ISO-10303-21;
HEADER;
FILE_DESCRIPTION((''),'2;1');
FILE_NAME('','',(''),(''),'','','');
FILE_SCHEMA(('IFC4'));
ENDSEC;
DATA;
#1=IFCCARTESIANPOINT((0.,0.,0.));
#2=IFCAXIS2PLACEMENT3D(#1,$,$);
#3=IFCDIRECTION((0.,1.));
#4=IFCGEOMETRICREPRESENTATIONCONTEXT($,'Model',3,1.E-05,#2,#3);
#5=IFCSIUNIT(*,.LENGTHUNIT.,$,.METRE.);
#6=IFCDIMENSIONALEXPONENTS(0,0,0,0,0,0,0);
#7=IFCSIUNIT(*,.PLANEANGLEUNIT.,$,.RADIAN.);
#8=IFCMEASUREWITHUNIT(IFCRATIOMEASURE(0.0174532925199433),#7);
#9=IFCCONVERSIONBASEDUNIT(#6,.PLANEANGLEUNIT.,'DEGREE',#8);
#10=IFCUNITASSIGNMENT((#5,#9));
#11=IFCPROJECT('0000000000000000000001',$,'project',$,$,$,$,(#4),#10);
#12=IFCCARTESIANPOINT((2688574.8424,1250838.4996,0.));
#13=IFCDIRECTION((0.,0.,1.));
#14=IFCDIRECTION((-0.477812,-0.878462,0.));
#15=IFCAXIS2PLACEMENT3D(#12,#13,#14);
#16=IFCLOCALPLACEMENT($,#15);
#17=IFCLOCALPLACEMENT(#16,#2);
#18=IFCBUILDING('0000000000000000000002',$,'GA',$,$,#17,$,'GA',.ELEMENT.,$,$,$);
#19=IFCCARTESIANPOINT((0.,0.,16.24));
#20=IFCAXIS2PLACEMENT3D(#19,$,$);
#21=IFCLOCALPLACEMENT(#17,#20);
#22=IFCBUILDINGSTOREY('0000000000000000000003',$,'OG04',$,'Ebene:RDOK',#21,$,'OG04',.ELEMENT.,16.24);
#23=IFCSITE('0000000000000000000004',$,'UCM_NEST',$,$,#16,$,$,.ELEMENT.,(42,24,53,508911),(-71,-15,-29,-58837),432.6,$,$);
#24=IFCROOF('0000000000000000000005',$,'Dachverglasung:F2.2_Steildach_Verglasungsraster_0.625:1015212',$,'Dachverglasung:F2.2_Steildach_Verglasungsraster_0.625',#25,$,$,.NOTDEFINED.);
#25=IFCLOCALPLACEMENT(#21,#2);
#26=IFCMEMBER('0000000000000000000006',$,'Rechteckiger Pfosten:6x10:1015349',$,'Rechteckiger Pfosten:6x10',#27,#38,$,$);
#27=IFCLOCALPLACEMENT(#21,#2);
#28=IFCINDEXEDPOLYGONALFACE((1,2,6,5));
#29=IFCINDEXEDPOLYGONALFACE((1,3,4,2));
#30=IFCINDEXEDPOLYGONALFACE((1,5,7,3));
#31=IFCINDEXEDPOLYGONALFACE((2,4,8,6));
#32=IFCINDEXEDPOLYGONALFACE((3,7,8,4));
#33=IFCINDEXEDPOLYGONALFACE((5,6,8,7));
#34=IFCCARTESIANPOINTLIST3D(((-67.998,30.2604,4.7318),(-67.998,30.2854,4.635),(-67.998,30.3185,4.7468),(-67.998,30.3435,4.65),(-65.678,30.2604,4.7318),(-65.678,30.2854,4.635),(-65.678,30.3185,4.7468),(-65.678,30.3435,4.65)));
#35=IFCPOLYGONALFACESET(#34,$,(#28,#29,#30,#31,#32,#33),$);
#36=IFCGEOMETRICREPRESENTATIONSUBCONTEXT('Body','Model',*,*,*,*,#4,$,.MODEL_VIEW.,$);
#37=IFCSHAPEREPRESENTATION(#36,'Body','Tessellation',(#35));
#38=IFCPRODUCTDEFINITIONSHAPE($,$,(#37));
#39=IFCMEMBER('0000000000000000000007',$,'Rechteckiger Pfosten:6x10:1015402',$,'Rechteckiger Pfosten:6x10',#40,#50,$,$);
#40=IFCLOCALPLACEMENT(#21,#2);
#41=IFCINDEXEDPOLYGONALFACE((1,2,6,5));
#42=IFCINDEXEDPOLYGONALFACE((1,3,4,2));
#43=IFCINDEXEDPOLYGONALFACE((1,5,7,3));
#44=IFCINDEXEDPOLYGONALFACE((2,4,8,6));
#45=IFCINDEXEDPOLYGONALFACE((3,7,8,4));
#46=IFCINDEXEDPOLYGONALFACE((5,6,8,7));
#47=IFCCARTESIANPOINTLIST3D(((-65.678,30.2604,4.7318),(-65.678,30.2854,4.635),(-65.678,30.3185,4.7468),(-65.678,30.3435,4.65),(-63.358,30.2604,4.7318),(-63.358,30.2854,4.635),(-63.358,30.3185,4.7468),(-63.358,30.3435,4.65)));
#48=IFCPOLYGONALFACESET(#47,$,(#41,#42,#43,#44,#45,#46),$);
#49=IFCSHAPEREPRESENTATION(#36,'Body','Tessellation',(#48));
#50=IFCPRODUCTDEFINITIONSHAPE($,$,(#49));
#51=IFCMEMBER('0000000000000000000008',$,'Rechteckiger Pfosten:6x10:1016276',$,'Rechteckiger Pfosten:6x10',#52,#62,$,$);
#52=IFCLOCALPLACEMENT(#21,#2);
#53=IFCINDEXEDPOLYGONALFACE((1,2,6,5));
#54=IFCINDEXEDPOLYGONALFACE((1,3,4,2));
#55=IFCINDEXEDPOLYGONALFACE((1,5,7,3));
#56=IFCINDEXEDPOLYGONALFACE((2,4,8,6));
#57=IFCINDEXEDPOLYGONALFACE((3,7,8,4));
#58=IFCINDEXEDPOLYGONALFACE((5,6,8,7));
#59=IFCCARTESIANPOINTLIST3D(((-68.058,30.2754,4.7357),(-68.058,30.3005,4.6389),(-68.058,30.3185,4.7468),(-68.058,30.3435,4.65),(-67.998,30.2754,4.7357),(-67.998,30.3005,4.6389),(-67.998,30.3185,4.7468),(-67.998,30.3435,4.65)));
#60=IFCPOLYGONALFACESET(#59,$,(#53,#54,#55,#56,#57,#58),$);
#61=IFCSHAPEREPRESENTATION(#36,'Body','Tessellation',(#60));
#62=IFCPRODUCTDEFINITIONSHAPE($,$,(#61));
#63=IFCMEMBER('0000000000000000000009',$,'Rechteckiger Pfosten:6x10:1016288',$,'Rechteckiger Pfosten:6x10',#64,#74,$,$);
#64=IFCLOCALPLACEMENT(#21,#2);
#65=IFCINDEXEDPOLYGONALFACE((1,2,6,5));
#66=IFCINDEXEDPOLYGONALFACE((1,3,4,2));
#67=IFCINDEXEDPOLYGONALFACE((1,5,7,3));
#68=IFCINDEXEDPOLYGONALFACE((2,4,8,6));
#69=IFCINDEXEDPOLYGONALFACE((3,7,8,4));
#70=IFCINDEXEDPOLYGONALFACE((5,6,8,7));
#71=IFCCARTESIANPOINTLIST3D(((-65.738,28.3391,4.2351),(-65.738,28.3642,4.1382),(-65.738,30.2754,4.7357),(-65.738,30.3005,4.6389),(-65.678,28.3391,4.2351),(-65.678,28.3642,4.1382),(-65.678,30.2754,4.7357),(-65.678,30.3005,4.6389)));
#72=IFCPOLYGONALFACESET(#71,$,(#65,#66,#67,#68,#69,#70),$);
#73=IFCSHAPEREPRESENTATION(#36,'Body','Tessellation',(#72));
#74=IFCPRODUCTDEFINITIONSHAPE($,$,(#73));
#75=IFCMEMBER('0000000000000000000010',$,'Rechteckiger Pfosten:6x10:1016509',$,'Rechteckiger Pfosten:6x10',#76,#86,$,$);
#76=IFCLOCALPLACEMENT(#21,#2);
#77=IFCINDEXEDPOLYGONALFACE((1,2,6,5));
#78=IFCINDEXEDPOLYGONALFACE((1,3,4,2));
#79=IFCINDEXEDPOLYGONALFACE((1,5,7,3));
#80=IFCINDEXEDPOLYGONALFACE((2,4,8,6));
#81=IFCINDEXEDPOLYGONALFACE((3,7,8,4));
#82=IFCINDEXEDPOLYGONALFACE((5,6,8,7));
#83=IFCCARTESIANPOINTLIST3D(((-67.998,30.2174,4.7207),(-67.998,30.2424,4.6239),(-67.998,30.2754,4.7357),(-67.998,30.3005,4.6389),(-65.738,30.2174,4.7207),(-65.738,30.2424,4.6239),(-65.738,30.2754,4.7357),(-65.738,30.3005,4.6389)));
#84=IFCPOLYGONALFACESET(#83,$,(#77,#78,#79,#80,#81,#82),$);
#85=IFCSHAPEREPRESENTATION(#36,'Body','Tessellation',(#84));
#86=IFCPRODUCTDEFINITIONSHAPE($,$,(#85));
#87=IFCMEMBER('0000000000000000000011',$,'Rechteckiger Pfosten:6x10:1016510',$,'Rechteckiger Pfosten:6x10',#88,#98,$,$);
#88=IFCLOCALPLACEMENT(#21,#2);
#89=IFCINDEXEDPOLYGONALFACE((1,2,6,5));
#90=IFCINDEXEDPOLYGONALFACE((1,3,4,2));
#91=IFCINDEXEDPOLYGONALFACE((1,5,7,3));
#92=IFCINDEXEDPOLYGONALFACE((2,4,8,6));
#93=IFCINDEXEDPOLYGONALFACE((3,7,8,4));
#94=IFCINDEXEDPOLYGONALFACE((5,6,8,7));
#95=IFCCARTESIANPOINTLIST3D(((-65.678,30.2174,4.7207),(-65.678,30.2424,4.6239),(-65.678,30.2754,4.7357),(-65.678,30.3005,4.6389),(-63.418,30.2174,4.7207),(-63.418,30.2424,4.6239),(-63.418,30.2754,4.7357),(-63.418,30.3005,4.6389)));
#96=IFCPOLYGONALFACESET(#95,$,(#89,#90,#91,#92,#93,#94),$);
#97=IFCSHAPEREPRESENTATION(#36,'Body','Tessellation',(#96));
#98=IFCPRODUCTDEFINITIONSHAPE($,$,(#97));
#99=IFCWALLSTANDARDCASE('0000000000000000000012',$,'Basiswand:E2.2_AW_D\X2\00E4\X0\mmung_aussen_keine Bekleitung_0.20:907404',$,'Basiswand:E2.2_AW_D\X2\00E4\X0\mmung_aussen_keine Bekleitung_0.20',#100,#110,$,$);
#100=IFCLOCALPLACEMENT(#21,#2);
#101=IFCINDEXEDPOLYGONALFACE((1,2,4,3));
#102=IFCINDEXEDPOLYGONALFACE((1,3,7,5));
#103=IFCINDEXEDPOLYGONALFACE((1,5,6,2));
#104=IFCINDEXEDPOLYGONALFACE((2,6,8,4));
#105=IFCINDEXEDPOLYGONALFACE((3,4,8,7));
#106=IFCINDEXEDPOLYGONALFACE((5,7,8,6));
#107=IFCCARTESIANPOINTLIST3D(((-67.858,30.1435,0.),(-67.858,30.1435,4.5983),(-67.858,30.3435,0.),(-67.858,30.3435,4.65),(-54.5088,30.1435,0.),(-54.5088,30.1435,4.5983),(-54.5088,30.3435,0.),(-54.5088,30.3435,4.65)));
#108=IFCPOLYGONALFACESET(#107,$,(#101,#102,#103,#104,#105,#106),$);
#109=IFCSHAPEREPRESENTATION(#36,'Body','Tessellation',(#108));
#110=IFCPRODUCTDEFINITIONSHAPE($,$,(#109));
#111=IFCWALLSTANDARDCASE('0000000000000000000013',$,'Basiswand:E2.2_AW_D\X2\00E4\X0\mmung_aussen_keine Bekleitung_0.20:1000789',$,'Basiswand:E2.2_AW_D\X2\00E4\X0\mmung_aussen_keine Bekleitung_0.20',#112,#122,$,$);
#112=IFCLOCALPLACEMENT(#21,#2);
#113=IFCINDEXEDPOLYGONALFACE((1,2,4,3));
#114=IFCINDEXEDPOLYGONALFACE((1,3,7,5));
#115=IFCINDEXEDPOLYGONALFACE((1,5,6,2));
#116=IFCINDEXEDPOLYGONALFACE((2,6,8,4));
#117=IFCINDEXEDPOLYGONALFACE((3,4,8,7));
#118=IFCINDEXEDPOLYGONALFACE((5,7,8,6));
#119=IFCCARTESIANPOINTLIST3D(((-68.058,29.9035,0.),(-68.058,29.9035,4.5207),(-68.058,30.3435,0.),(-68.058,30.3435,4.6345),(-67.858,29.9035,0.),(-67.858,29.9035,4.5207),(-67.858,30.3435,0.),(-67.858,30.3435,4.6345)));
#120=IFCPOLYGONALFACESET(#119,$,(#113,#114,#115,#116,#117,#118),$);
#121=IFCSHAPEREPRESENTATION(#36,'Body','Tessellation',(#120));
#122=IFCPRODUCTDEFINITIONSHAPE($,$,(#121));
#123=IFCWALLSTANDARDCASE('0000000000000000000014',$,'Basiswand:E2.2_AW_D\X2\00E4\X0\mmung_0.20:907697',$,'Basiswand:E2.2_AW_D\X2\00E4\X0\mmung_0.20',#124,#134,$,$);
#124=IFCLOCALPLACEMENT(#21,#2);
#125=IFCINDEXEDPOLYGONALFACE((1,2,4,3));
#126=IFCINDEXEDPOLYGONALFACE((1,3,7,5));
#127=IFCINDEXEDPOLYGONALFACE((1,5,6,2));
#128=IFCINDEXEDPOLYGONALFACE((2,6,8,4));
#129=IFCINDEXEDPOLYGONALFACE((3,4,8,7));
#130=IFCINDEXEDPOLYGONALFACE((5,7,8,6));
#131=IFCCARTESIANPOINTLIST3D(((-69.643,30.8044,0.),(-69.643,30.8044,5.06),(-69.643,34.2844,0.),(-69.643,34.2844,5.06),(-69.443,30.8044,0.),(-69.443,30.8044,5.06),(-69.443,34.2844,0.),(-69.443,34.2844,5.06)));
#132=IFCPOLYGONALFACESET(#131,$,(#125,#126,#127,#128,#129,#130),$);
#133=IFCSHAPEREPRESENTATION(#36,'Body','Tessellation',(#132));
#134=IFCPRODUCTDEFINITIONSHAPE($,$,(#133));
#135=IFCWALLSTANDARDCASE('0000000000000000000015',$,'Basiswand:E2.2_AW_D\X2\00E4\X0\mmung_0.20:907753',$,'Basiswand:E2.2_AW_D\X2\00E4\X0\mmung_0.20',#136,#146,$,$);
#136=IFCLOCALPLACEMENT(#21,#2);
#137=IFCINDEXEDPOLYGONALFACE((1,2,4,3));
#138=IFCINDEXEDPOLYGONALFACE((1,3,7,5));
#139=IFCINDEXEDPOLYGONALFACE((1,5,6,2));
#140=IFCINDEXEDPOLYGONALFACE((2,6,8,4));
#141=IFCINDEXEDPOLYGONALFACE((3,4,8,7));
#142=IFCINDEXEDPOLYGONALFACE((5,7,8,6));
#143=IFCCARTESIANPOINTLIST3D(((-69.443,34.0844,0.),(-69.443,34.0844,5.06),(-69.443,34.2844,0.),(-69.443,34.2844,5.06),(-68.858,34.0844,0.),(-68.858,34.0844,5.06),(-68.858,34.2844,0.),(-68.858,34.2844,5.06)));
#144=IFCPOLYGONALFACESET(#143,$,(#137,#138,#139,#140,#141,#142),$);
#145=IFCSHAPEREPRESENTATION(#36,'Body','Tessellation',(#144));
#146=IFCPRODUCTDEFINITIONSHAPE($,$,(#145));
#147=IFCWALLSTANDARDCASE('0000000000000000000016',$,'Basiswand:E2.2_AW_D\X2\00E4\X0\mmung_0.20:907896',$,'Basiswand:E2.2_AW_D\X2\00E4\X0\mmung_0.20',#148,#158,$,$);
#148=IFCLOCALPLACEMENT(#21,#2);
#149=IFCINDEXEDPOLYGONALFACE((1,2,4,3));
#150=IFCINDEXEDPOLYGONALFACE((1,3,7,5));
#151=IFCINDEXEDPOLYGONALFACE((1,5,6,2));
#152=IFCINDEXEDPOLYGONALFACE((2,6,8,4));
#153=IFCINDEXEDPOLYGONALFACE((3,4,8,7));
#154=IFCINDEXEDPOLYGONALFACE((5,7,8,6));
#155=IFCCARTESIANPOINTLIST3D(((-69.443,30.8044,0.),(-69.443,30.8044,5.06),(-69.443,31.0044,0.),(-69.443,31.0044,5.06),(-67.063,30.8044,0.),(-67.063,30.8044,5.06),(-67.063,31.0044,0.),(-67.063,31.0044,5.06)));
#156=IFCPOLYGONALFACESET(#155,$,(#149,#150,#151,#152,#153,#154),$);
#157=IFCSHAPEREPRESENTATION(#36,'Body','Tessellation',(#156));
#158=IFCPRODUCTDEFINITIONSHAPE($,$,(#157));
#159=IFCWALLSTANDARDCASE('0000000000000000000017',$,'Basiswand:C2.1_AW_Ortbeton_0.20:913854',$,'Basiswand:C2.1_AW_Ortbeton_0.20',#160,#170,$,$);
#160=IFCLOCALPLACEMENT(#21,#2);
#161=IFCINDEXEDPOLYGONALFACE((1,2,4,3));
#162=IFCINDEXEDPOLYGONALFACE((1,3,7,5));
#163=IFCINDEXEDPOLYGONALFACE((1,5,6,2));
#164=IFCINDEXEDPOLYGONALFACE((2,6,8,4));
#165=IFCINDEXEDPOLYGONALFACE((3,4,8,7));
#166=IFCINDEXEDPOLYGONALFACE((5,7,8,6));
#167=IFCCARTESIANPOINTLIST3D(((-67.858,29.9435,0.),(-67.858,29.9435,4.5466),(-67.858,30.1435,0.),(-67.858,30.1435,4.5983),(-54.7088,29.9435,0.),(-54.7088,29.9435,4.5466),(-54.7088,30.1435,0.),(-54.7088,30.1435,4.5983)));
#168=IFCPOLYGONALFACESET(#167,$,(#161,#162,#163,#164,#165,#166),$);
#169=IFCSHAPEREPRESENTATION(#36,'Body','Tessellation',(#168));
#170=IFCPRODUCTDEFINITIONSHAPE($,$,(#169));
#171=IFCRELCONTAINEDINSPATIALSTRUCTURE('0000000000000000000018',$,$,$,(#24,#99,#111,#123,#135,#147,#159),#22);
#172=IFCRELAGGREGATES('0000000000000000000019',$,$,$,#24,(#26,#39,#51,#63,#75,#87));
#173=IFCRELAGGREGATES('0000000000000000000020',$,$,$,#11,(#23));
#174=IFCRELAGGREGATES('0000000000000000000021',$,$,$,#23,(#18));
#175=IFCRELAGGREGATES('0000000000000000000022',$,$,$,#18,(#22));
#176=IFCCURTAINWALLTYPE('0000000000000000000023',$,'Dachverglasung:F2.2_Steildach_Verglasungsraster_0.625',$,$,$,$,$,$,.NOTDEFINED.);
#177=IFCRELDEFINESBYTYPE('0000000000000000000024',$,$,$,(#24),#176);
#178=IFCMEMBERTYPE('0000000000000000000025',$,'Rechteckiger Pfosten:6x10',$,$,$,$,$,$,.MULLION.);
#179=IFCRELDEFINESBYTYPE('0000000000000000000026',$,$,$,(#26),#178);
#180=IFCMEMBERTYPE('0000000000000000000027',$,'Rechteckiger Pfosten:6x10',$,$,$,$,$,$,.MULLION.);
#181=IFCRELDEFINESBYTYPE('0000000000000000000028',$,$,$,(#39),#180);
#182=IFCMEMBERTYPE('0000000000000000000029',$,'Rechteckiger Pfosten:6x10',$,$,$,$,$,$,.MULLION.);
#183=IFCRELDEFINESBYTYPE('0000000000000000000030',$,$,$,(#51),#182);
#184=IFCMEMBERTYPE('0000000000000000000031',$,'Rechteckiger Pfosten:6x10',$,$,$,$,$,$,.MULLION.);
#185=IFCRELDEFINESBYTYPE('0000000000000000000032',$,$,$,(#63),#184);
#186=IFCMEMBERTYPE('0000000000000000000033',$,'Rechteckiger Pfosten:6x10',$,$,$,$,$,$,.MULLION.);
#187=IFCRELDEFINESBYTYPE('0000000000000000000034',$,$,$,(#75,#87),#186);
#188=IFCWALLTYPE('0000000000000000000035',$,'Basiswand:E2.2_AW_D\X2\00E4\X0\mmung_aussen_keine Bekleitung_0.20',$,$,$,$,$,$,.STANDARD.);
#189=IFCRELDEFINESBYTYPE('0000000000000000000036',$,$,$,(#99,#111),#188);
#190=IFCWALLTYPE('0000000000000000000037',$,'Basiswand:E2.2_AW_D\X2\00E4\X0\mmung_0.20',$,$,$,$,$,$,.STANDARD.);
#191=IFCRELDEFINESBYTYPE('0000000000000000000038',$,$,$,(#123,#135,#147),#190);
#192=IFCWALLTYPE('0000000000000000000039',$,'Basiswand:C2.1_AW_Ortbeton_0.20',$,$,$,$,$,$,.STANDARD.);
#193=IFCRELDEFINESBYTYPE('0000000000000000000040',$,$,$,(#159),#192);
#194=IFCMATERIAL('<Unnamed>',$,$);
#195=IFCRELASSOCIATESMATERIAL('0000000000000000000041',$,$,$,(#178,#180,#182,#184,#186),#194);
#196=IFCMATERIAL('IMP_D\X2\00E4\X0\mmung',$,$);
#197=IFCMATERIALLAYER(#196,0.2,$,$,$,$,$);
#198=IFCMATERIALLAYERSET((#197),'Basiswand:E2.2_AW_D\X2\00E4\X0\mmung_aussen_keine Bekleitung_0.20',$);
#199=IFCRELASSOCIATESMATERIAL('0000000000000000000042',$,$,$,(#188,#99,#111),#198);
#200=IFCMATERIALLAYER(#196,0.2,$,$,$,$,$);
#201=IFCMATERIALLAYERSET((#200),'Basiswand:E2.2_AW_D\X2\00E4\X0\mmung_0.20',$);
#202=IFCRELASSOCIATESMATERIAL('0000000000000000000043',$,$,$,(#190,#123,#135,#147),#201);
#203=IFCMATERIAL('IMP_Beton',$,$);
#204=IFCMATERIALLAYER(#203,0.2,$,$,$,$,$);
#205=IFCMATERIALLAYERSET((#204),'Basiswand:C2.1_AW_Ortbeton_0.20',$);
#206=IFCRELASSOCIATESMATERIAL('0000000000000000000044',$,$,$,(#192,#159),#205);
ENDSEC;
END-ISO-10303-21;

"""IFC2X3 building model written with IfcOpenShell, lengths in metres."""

from ifc_helpers import new_model, entity, si_unit, converted_unit, direction, frame, frame_2d, origin, origin_2d_with_axis, place, context, subcontext, project, spatial, polyline, rectangle, extrude, clip, halfspace, bounded_halfspace, source, transform, mapped, material, layer, layer_set, layer_usage, type_object, type_shapes, element, aggregate, save


model = new_model("IFC2X3")

# Units and contexts
model_context = context("Model", 3, precision=1e-05, world=origin(), true_north=direction((0.0, 1.0)))
body_context = subcontext(model_context, "Body", "Model", "MODEL_VIEW")
ifc_project = project(units=[si_unit("LENGTHUNIT", "METRE"), converted_unit("PLANEANGLEUNIT", "DEGREE", entity("IfcRatioMeasure", 0.0174532925199433), si_unit("PLANEANGLEUNIT", "RADIAN"), dimensions=[0, 0, 0, 0, 0, 0, 0])], contexts=[model_context])

# Site, building, storey
site_placement = place(None, frame((2688574.8424, 1250838.4996, 0.0), z_axis=(0.0, 0.0, 1.0), x_axis=(-0.477812, -0.878462, 0.0)))
site = spatial("IfcSite", under=ifc_project, at=site_placement, Name="UCM_NEST", CompositionType="ELEMENT", RefLatitude=(42, 24, 53, 508911), RefLongitude=(-71, -15, -29, -58837), RefElevation=432.6)
building_placement = place(site_placement, origin())
building = spatial("IfcBuilding", under=site, at=building_placement, Name="GA", LongName="GA", CompositionType="ELEMENT")
storey_placement = place(building_placement, frame((0.0, 0.0, 16.24)))
storey = spatial("IfcBuildingStorey", under=building, at=storey_placement, Name="OG04", ObjectType="Ebene:RDOK", LongName="OG04", CompositionType="ELEMENT", Elevation=16.24)

# Roof, members
curtain_wall_type = type_object("IfcCurtainWallType", Name="Dachverglasung:F2.2_Steildach_Verglasungsraster_0.625", PredefinedType="NOTDEFINED")
roof_placement = place(storey_placement, frame((0.0, 0.0, -16.24)))
roof = element("IfcRoof", 1, at=roof_placement, inside=storey, type_object=curtain_wall_type, Name="Dachverglasung:F2.2_Steildach_Verglasungsraster_0.625:1015212", ObjectType="Dachverglasung:F2.2_Steildach_Verglasungsraster_0.625", ShapeType="NOTDEFINED")
ifc_material_1 = material(Name="<Unnamed>")
member_type_1 = type_object("IfcMemberType", Name="Rechteckiger Pfosten:6x10", PredefinedType="MULLION", material=ifc_material_1)
shared_shape_1 = source(origin(), body_context, "Body", "SweptSolid", [
    extrude(rectangle(XDim=0.1, YDim=0.06, at=origin_2d_with_axis()), frame((-0.03, -0.05, -2.32), z_axis=(0.0, 0.0, 1.0), x_axis=(0.0, -1.0, 0.0)), (0.0, 0.0, 1.0), 2.32),
])
type_shapes(member_type_1, [shared_shape_1])
member_1_placement = place(roof_placement, frame((-67.998, 30.3435, 20.89), z_axis=(-1.0, 0.0, 0.0), x_axis=(0.0, 0.968163, 0.250322)))
member_1 = element("IfcMember", 2, at=member_1_placement, type_object=member_type_1, Name="Rechteckiger Pfosten:6x10:1015349", ObjectType="Rechteckiger Pfosten:6x10", context=body_context, shape_type="MappedRepresentation", body=[
    mapped(shared_shape_1, transform((0.0, 0.0, 0.0), scale=1.0)),
])
member_type_2 = type_object("IfcMemberType", Name="Rechteckiger Pfosten:6x10", PredefinedType="MULLION", material=ifc_material_1)
shared_shape_2 = source(origin(), body_context, "Body", "SweptSolid", [
    extrude(rectangle(XDim=0.1, YDim=0.06, at=origin_2d_with_axis()), frame((-0.03, -0.05, -2.32), z_axis=(0.0, 0.0, 1.0), x_axis=(0.0, -1.0, 0.0)), (0.0, 0.0, 1.0), 2.32),
])
type_shapes(member_type_2, [shared_shape_2])
member_2_placement = place(roof_placement, frame((-65.678, 30.3435, 20.89), z_axis=(-1.0, 0.0, 0.0), x_axis=(0.0, 0.968163, 0.250322)))
member_2 = element("IfcMember", 3, at=member_2_placement, type_object=member_type_2, Name="Rechteckiger Pfosten:6x10:1015402", ObjectType="Rechteckiger Pfosten:6x10", context=body_context, shape_type="MappedRepresentation", body=[
    mapped(shared_shape_2, transform((0.0, 0.0, 0.0), scale=1.0)),
])
member_type_3 = type_object("IfcMemberType", Name="Rechteckiger Pfosten:6x10", PredefinedType="MULLION", material=ifc_material_1)
shared_shape_3 = source(origin(), body_context, "Body", "SweptSolid", [
    extrude(rectangle(XDim=0.1, YDim=0.06, at=origin_2d_with_axis()), frame((-0.03, -0.05, -0.0444), z_axis=(0.0, 0.0, 1.0), x_axis=(0.0, -1.0, 0.0)), (0.0, 0.0, 1.0), 0.0444),
])
type_shapes(member_type_3, [shared_shape_3])
member_3_placement = place(roof_placement, frame((-68.058, 30.3005, 20.8789), z_axis=(0.0, -0.968163, -0.250322), x_axis=(-1.0, 0.0, 0.0)))
member_3 = element("IfcMember", 4, at=member_3_placement, type_object=member_type_3, Name="Rechteckiger Pfosten:6x10:1016276", ObjectType="Rechteckiger Pfosten:6x10", context=body_context, shape_type="MappedRepresentation", body=[
    mapped(shared_shape_3, transform((0.0, 0.0, 0.0), scale=1.0)),
])
member_type_4 = type_object("IfcMemberType", Name="Rechteckiger Pfosten:6x10", PredefinedType="MULLION", material=ifc_material_1)
shared_shape_4 = source(origin(), body_context, "Body", "SweptSolid", [
    extrude(rectangle(XDim=0.1, YDim=0.06, at=origin_2d_with_axis()), frame((-0.03, -0.05, -2.0), z_axis=(0.0, 0.0, 1.0), x_axis=(0.0, -1.0, 0.0)), (0.0, 0.0, 1.0), 2.0),
])
type_shapes(member_type_4, [shared_shape_4])
member_4_placement = place(roof_placement, frame((-65.678, 30.3005, 20.8789), z_axis=(0.0, 0.968163, 0.250322), x_axis=(1.0, 0.0, 0.0)))
member_4 = element("IfcMember", 5, at=member_4_placement, type_object=member_type_4, Name="Rechteckiger Pfosten:6x10:1016288", ObjectType="Rechteckiger Pfosten:6x10", context=body_context, shape_type="MappedRepresentation", body=[
    mapped(shared_shape_4, transform((0.0, 0.0, 0.0), scale=1.0)),
])
member_type_5 = type_object("IfcMemberType", Name="Rechteckiger Pfosten:6x10", PredefinedType="MULLION", material=ifc_material_1)
shared_shape_5 = source(origin(), body_context, "Body", "SweptSolid", [
    extrude(rectangle(XDim=0.1, YDim=0.06, at=origin_2d_with_axis()), frame((-0.03, -0.05, -2.26), z_axis=(0.0, 0.0, 1.0), x_axis=(0.0, -1.0, 0.0)), (0.0, 0.0, 1.0), 2.26),
])
type_shapes(member_type_5, [shared_shape_5])
member_5_placement = place(roof_placement, frame((-67.998, 30.3005, 20.8789), z_axis=(-1.0, 0.0, 0.0), x_axis=(0.0, 0.968163, 0.250322)))
member_5 = element("IfcMember", 6, at=member_5_placement, type_object=member_type_5, Name="Rechteckiger Pfosten:6x10:1016509", ObjectType="Rechteckiger Pfosten:6x10", context=body_context, shape_type="MappedRepresentation", body=[
    mapped(shared_shape_5, transform((0.0, 0.0, 0.0), scale=1.0)),
])
member_6_placement = place(roof_placement, frame((-65.678, 30.3005, 20.8789), z_axis=(-1.0, 0.0, 0.0), x_axis=(0.0, 0.968163, 0.250322)))
member_6 = element("IfcMember", 7, at=member_6_placement, type_object=member_type_5, Name="Rechteckiger Pfosten:6x10:1016510", ObjectType="Rechteckiger Pfosten:6x10", context=body_context, shape_type="MappedRepresentation", body=[
    mapped(shared_shape_5, transform((0.0, 0.0, 0.0), scale=1.0)),
])
aggregate(roof, [member_1, member_2, member_3, member_4, member_5, member_6])

# Walls
ifc_material_2 = material(Name="IMP_Dämmung")
ifc_layer_1 = layer(ifc_material_2, 0.2)
ifc_layer_set_1 = layer_set([ifc_layer_1], Name="Basiswand:E2.2_AW_Dämmung_aussen_keine Bekleitung_0.20")
ifc_layer_usage_1 = layer_usage(ifc_layer_set_1, "AXIS2", "NEGATIVE", 0.1)
wall_type_1 = type_object("IfcWallType", Name="Basiswand:E2.2_AW_Dämmung_aussen_keine Bekleitung_0.20", PredefinedType="STANDARD", material=ifc_layer_set_1)
wall_1_placement = place(storey_placement, frame((-67.858, 30.2435, 0.0)))
element("IfcWallStandardCase", 8, at=wall_1_placement, inside=storey, type_object=wall_type_1, material=ifc_layer_usage_1, Name="Basiswand:E2.2_AW_Dämmung_aussen_keine Bekleitung_0.20:907404", ObjectType="Basiswand:E2.2_AW_Dämmung_aussen_keine Bekleitung_0.20", context=body_context, shape_type="Clipping", body=[
    clip(extrude(rectangle(XDim=13.3492, YDim=0.2, at=frame_2d((6.6746, 0.0), x_axis=(-1.0, 0.0))), origin(), (0.0, 0.0, 1.0), 4.65), bounded_halfspace(frame((0.0, -0.1, 4.5983), z_axis=(0.0, -0.250322, 0.968163), x_axis=(1.0, 0.0, 0.0)), False, frame((0.0, -0.1, 4.5983)), polyline([(0.0, 0.0), (13.3492, 0.0), (13.3492, 0.2), (0.0, 0.2), (0.0, 0.0)]))),
])
ifc_layer_usage_2 = layer_usage(ifc_layer_set_1, "AXIS2", "NEGATIVE", 0.1)
wall_2_placement = place(storey_placement, frame((-67.958, 30.3435, 0.0), z_axis=(0.0, 0.0, 1.0), x_axis=(0.0, -1.0, 0.0)))
element("IfcWallStandardCase", 9, at=wall_2_placement, inside=storey, type_object=wall_type_1, material=ifc_layer_usage_2, Name="Basiswand:E2.2_AW_Dämmung_aussen_keine Bekleitung_0.20:1000789", ObjectType="Basiswand:E2.2_AW_Dämmung_aussen_keine Bekleitung_0.20", context=body_context, shape_type="Clipping", body=[
    clip(extrude(rectangle(XDim=0.44, YDim=0.2, at=frame_2d((0.22, 0.0), x_axis=(-1.0, 0.0))), origin(), (0.0, 0.0, 1.0), 4.6345), halfspace(frame((0.0, -0.1, 4.6345), z_axis=(0.250322, 0.0, 0.968163), x_axis=(0.0, 1.0, 0.0)), False)),
])
ifc_layer_2 = layer(ifc_material_2, 0.2)
ifc_layer_set_2 = layer_set([ifc_layer_2], Name="Basiswand:E2.2_AW_Dämmung_0.20")
ifc_layer_usage_3 = layer_usage(ifc_layer_set_2, "AXIS2", "NEGATIVE", 0.1)
wall_type_2 = type_object("IfcWallType", Name="Basiswand:E2.2_AW_Dämmung_0.20", PredefinedType="STANDARD", material=ifc_layer_set_2)
wall_3_placement = place(storey_placement, frame((-69.543, 30.8044, 0.0), z_axis=(0.0, 0.0, 1.0), x_axis=(0.0, 1.0, 0.0)))
element("IfcWallStandardCase", 10, at=wall_3_placement, inside=storey, type_object=wall_type_2, material=ifc_layer_usage_3, Name="Basiswand:E2.2_AW_Dämmung_0.20:907697", ObjectType="Basiswand:E2.2_AW_Dämmung_0.20", context=body_context, shape_type="SweptSolid", body=[
    extrude(rectangle(XDim=3.48, YDim=0.2, at=frame_2d((1.74, 0.0), x_axis=(-1.0, 0.0))), origin(), (0.0, 0.0, 1.0), 5.06),
])
ifc_layer_usage_4 = layer_usage(ifc_layer_set_2, "AXIS2", "NEGATIVE", 0.1)
wall_4_placement = place(storey_placement, frame((-69.443, 34.1844, 0.0)))
element("IfcWallStandardCase", 11, at=wall_4_placement, inside=storey, type_object=wall_type_2, material=ifc_layer_usage_4, Name="Basiswand:E2.2_AW_Dämmung_0.20:907753", ObjectType="Basiswand:E2.2_AW_Dämmung_0.20", context=body_context, shape_type="SweptSolid", body=[
    extrude(rectangle(XDim=0.585, YDim=0.2, at=frame_2d((0.2925, 0.0), x_axis=(-1.0, 0.0))), origin(), (0.0, 0.0, 1.0), 5.06),
])
ifc_layer_usage_5 = layer_usage(ifc_layer_set_2, "AXIS2", "NEGATIVE", 0.1)
wall_5_placement = place(storey_placement, frame((-67.063, 30.9044, 0.0), z_axis=(0.0, 0.0, 1.0), x_axis=(-1.0, 0.0, 0.0)))
element("IfcWallStandardCase", 12, at=wall_5_placement, inside=storey, type_object=wall_type_2, material=ifc_layer_usage_5, Name="Basiswand:E2.2_AW_Dämmung_0.20:907896", ObjectType="Basiswand:E2.2_AW_Dämmung_0.20", context=body_context, shape_type="SweptSolid", body=[
    extrude(rectangle(XDim=2.38, YDim=0.2, at=frame_2d((1.19, 0.0), x_axis=(-1.0, 0.0))), origin(), (0.0, 0.0, 1.0), 5.06),
])

# Shared definitions
ifc_material_3 = material(Name="IMP_Beton")

# Wall
ifc_layer_3 = layer(ifc_material_3, 0.2)
ifc_layer_set_3 = layer_set([ifc_layer_3], Name="Basiswand:C2.1_AW_Ortbeton_0.20")
ifc_layer_usage_6 = layer_usage(ifc_layer_set_3, "AXIS2", "NEGATIVE", 0.1)
wall_type_3 = type_object("IfcWallType", Name="Basiswand:C2.1_AW_Ortbeton_0.20", PredefinedType="STANDARD", material=ifc_layer_set_3)
wall_6_placement = place(storey_placement, frame((-67.858, 30.0435, 0.0)))
element("IfcWallStandardCase", 13, at=wall_6_placement, inside=storey, type_object=wall_type_3, material=ifc_layer_usage_6, Name="Basiswand:C2.1_AW_Ortbeton_0.20:913854", ObjectType="Basiswand:C2.1_AW_Ortbeton_0.20", context=body_context, shape_type="Clipping", body=[
    clip(extrude(rectangle(XDim=13.1492, YDim=0.2, at=frame_2d((6.5746, 0.0), x_axis=(-1.0, 0.0))), origin(), (0.0, 0.0, 1.0), 4.5983), bounded_halfspace(frame((0.0, -0.1, 4.5466), z_axis=(0.0, -0.250322, 0.968163), x_axis=(1.0, 0.0, 0.0)), False, frame((0.0, -0.1, 4.5466)), polyline([(0.0, 0.0), (13.1492, 0.0), (13.1492, 0.2), (0.0, 0.2), (0.0, 0.0)]))),
])

save(model, "model.ifc")
